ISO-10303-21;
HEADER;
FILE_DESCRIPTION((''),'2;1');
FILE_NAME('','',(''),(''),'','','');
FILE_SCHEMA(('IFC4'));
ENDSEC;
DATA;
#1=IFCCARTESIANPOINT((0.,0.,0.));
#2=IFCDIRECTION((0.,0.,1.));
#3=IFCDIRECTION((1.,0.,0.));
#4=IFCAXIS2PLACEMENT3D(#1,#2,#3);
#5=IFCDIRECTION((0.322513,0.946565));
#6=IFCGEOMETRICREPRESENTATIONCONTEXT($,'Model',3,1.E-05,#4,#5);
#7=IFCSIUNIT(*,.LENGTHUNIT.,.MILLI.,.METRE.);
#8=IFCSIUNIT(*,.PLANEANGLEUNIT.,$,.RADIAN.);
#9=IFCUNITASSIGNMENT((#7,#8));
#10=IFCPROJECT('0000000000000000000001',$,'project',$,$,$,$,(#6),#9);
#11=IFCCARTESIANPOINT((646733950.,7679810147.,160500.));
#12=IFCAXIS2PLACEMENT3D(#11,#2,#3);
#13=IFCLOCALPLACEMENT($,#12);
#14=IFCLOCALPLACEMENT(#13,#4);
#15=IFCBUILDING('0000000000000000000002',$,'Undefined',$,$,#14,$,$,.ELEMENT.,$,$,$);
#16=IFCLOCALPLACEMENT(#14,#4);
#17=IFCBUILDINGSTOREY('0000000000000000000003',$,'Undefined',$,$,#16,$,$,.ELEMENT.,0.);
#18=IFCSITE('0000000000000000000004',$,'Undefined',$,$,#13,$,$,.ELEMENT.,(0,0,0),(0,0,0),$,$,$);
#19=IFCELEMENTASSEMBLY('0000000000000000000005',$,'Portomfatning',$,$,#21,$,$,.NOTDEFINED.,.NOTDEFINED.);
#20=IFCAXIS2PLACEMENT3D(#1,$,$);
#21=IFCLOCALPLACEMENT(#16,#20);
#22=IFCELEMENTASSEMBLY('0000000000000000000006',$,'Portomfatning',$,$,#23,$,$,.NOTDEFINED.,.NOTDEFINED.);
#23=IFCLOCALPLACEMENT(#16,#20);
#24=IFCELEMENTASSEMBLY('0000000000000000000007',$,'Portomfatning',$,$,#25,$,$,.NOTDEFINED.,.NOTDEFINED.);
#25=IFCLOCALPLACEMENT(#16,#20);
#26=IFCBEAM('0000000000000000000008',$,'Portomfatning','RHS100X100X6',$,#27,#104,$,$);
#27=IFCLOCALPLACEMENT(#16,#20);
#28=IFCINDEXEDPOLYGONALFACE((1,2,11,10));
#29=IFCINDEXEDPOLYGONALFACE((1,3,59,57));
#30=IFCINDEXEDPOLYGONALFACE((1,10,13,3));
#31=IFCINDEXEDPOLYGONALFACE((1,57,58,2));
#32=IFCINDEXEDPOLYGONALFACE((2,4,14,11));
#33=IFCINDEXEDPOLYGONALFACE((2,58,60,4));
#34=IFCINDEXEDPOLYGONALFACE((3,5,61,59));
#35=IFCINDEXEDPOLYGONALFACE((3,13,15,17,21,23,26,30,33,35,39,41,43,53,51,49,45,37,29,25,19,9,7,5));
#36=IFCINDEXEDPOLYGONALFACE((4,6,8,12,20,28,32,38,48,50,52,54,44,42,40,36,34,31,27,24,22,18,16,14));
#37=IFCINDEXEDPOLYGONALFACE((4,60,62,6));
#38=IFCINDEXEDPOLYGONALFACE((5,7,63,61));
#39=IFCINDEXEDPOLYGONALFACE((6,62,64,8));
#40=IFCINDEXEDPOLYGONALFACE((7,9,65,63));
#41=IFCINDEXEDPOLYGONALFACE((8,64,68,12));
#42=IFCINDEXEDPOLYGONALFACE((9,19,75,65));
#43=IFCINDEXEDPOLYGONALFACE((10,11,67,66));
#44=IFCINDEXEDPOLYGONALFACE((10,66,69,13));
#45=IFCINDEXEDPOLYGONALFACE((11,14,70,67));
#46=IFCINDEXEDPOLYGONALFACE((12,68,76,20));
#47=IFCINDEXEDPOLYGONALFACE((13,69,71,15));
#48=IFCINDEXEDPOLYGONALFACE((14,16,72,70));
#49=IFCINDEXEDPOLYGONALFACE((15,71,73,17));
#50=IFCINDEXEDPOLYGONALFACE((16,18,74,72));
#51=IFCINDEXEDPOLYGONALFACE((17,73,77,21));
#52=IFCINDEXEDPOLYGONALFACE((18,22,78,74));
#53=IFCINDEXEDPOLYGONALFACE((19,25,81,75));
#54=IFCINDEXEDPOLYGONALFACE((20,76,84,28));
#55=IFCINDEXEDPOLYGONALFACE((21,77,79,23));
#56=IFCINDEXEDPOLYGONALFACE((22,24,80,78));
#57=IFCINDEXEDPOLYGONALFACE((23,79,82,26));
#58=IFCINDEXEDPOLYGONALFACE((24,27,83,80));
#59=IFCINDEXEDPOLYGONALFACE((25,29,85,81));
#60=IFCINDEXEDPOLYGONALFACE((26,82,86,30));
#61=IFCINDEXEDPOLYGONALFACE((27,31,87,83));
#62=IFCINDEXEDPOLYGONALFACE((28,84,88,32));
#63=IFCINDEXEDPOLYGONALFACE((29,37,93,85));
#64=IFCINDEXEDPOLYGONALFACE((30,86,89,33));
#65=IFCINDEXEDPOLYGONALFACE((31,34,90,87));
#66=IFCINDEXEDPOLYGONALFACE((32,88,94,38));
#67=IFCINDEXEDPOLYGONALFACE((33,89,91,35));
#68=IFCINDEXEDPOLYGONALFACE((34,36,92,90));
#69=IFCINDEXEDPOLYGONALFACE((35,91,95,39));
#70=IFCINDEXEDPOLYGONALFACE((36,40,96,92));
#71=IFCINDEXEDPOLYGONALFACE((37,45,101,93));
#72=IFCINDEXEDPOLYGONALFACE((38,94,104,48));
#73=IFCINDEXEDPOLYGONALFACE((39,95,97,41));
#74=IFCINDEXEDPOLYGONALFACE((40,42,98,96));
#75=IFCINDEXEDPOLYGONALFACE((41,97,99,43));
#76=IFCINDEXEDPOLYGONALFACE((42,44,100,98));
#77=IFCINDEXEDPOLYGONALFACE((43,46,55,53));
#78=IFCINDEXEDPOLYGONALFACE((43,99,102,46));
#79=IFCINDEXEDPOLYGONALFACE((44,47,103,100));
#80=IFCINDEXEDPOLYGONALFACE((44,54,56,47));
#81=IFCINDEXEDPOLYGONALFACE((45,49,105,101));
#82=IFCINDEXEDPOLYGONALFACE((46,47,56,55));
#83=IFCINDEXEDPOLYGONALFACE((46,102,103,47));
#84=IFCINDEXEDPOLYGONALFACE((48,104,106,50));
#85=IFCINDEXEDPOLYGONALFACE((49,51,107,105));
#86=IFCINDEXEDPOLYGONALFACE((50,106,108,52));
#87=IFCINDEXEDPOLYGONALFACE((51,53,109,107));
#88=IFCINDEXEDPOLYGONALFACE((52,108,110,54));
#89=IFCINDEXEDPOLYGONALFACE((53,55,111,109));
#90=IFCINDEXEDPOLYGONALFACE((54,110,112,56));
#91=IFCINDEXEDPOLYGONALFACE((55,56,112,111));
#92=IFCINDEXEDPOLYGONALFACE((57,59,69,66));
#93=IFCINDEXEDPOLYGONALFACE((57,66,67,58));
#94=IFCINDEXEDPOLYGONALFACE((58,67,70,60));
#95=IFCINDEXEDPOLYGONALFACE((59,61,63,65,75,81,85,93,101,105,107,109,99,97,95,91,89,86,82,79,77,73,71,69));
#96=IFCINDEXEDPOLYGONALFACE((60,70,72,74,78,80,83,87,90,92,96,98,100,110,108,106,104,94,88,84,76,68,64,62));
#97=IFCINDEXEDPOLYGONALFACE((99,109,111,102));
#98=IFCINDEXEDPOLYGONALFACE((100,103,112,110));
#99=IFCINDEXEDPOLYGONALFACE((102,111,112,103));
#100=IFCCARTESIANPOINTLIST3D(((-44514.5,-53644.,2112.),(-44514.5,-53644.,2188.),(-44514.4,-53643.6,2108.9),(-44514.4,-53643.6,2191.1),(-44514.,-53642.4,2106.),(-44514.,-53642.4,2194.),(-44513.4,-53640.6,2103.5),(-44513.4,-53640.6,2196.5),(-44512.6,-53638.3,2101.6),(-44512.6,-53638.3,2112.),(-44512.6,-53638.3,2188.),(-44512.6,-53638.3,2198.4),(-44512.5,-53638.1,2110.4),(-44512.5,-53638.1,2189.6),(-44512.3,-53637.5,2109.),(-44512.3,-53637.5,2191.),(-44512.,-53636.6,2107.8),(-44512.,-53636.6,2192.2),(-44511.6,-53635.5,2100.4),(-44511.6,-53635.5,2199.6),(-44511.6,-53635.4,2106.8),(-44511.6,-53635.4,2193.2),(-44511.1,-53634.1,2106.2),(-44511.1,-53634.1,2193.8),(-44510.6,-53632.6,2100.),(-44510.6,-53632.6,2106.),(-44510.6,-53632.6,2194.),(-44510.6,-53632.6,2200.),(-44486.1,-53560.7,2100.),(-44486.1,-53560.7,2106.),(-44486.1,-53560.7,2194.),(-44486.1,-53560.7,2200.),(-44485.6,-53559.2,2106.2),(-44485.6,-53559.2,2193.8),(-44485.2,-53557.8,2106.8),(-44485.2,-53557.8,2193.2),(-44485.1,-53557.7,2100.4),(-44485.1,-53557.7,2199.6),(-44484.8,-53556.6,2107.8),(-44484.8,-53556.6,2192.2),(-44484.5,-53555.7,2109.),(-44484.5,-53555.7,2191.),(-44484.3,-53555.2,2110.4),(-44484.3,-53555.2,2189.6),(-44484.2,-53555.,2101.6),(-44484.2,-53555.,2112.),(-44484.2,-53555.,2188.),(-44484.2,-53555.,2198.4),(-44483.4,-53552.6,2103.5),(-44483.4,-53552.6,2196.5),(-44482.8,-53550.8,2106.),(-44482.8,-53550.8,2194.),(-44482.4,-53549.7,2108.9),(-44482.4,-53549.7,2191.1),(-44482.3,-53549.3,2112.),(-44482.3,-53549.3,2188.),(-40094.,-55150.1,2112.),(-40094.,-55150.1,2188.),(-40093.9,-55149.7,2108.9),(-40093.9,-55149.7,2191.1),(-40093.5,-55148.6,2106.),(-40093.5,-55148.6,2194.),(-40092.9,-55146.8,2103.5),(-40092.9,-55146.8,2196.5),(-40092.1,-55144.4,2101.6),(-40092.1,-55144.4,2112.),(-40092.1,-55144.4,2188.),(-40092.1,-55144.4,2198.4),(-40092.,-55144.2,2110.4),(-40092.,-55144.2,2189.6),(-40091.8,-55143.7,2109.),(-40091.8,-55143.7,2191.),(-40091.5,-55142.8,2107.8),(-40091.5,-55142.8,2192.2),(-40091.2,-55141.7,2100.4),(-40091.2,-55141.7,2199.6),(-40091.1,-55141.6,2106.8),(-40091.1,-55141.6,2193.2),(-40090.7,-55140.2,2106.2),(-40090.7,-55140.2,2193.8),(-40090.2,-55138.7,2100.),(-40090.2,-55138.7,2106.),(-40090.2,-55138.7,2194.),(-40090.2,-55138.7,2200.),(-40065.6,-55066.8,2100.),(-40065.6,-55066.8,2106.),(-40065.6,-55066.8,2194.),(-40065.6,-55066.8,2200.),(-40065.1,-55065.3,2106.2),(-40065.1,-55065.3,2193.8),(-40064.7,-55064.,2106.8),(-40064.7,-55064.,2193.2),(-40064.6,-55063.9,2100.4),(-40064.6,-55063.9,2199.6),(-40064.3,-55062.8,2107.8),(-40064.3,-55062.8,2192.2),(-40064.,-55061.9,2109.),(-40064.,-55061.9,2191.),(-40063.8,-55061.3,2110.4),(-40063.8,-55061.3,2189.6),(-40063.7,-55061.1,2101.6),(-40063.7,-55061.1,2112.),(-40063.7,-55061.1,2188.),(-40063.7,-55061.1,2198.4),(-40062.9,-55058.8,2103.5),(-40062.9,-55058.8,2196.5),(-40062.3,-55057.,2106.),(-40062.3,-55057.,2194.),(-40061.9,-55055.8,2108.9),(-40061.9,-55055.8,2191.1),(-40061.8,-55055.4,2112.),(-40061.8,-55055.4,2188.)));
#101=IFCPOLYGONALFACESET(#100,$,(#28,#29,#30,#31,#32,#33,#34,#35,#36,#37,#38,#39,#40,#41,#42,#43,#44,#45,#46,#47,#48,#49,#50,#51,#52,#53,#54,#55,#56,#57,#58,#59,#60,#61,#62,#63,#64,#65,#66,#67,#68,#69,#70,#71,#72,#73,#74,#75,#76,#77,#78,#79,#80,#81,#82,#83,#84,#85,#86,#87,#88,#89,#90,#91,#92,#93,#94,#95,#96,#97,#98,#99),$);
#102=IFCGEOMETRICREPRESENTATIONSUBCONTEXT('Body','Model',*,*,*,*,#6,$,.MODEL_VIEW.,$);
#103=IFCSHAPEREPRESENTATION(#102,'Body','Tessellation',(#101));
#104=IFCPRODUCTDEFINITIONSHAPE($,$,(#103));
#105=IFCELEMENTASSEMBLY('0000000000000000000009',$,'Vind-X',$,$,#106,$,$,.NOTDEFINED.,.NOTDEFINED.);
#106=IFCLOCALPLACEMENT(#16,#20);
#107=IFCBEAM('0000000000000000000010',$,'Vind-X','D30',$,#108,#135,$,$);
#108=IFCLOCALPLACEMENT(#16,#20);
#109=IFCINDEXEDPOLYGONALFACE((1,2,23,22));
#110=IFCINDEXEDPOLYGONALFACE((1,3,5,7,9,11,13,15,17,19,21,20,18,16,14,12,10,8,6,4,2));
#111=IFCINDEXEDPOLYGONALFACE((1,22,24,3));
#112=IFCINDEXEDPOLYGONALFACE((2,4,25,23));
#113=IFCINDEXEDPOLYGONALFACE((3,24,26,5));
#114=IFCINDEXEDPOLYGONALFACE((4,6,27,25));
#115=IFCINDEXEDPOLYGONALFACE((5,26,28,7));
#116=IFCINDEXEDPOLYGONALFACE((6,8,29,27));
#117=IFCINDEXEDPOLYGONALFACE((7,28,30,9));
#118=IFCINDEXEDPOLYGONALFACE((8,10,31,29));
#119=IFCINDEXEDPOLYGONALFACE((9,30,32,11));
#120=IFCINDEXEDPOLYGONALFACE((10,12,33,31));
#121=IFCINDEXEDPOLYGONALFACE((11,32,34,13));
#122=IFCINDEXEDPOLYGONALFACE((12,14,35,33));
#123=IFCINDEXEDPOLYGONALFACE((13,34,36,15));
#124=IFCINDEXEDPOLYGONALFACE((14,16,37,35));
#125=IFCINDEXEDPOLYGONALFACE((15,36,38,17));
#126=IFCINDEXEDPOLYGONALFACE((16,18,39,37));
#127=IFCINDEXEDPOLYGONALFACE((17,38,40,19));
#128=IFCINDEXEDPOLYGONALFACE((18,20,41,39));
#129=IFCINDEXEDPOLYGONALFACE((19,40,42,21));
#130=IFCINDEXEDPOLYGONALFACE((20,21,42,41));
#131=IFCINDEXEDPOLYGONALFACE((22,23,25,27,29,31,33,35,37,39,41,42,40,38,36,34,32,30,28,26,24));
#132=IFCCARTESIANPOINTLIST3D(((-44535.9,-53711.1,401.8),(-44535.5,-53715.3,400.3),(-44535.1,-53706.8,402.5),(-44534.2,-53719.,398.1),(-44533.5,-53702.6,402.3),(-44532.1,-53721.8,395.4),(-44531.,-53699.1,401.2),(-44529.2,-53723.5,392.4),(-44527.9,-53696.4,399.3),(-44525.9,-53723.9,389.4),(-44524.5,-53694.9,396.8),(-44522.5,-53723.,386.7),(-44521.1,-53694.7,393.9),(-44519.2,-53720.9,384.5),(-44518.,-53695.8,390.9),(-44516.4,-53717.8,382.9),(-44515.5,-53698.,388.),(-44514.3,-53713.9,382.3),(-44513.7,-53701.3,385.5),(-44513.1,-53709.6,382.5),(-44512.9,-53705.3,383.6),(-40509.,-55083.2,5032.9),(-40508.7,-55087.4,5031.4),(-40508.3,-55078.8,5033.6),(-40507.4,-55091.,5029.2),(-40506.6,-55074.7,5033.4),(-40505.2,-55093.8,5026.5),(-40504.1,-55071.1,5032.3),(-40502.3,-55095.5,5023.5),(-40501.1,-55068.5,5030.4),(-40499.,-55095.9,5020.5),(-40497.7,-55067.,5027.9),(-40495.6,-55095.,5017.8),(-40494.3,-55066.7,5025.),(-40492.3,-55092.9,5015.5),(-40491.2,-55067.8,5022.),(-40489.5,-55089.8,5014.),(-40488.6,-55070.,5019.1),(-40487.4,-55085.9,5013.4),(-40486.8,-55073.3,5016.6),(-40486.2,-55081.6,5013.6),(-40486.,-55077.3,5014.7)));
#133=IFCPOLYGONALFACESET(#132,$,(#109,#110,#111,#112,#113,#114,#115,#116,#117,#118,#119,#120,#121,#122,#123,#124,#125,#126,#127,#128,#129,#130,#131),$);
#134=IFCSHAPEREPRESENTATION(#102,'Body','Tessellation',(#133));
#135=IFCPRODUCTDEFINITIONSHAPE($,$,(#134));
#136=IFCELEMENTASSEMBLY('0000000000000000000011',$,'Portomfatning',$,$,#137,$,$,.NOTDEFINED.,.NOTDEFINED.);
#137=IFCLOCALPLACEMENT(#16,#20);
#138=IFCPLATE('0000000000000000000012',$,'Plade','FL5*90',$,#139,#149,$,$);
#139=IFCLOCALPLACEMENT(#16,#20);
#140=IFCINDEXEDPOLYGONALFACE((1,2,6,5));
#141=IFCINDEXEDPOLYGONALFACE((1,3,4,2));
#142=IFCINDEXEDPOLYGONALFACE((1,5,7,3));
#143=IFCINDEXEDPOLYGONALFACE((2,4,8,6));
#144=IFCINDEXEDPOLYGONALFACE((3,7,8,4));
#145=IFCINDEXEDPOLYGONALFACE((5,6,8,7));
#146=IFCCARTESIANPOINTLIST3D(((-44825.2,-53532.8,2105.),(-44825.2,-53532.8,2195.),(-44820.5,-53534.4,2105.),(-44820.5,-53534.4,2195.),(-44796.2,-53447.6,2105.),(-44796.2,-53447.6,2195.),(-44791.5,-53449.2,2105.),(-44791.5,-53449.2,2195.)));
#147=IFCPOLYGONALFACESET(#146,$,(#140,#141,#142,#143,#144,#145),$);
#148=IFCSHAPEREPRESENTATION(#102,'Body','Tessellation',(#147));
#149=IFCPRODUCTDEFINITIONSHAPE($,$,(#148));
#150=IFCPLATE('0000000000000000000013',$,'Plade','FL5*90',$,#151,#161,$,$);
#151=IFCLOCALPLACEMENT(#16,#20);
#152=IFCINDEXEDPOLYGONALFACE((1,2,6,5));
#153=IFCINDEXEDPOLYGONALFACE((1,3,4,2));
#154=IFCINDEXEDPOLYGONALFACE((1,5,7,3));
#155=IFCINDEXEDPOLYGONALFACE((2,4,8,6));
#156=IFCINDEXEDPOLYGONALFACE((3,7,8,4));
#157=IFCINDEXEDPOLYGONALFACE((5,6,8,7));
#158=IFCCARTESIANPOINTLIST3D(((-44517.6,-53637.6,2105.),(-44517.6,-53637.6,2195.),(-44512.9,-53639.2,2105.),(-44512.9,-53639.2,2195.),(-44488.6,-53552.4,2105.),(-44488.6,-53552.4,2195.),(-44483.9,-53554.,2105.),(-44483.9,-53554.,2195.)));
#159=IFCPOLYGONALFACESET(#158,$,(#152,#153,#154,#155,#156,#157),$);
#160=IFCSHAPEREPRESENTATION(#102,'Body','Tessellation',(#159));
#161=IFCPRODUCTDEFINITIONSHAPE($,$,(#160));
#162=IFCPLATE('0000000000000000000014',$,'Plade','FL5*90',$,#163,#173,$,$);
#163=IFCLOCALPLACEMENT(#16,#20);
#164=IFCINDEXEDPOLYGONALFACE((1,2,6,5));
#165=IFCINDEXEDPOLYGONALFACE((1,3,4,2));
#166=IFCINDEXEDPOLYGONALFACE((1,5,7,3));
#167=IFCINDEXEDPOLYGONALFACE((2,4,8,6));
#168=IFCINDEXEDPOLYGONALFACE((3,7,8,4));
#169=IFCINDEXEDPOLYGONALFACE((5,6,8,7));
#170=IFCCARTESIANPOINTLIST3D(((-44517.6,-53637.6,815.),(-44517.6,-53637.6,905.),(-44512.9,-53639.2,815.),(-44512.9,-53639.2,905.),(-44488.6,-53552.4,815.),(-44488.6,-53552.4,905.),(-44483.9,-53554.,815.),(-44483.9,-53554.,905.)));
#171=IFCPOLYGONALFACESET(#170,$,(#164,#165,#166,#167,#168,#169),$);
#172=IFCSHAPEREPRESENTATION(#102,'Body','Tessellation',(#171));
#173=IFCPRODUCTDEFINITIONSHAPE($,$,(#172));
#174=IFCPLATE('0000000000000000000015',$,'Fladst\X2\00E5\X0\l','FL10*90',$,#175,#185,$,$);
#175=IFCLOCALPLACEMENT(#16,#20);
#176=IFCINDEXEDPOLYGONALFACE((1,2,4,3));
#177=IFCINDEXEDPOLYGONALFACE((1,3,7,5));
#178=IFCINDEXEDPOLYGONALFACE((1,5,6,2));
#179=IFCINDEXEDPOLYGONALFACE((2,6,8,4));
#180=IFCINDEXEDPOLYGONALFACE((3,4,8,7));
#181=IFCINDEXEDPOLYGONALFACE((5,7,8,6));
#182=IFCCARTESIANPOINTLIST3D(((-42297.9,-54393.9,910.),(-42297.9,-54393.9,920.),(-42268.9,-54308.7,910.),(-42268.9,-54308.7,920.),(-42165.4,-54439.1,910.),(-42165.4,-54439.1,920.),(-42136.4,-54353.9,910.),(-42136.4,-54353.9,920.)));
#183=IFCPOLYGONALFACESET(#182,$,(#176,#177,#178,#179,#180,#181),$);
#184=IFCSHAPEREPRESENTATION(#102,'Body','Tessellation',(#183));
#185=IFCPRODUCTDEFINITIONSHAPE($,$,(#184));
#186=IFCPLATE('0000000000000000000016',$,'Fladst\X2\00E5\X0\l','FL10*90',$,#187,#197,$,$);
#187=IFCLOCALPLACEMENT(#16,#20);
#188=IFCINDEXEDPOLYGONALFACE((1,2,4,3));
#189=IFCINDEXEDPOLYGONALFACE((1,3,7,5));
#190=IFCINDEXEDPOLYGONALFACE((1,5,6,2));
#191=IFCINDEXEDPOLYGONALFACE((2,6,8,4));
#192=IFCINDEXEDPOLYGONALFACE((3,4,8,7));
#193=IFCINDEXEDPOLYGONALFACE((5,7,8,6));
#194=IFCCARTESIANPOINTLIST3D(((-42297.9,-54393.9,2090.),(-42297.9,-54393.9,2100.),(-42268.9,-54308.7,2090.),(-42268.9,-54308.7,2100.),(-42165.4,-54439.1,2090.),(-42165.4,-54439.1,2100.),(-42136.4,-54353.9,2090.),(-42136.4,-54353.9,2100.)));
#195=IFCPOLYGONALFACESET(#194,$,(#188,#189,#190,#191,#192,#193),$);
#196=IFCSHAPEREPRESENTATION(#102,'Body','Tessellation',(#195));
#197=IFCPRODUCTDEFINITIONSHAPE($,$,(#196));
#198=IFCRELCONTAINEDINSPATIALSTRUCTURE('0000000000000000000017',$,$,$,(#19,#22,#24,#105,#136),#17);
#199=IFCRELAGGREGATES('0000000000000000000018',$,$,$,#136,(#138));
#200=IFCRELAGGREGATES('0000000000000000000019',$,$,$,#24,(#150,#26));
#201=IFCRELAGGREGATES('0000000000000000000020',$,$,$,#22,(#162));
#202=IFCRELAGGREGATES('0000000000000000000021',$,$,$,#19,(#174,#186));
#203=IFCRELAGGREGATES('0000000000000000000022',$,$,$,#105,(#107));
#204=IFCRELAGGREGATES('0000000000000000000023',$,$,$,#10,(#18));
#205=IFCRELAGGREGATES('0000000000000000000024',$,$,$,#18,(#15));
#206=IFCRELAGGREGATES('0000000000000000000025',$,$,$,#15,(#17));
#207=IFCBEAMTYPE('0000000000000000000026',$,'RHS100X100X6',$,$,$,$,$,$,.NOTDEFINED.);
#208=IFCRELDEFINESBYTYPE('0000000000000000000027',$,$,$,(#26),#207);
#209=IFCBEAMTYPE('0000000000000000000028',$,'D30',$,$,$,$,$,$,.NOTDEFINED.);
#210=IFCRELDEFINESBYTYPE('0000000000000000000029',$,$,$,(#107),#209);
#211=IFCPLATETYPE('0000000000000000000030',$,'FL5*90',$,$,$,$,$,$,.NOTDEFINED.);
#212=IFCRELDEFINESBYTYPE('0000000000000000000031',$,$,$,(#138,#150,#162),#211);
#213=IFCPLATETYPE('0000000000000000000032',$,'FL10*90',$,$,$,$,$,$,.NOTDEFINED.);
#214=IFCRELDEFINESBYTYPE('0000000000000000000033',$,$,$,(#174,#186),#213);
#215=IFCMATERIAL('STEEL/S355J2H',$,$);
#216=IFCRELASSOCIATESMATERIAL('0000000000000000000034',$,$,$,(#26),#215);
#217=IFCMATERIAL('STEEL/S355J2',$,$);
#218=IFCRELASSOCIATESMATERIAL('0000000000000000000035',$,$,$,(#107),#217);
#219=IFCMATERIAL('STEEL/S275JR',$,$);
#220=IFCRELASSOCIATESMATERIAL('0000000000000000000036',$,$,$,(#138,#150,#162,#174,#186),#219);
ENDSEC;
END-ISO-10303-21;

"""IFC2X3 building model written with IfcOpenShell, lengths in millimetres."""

from ifc_helpers import new_model, si_unit, direction, frame, origin_with_axes, origin_2d_with_axis, place, context, subcontext, project, spatial, polyline, hollow_rectangle, circle, outline, extrude, clip, halfspace, material, type_object, element, aggregate, save


model = new_model("IFC2X3")

# Units and contexts
model_context = context("Model", 3, precision=1e-05, world=origin_with_axes(), true_north=direction((0.322513, 0.946565)))
body_context = subcontext(model_context, "Body", "Model", "MODEL_VIEW")
ifc_project = project(units=[si_unit("LENGTHUNIT", "METRE", prefix="MILLI"), si_unit("PLANEANGLEUNIT", "RADIAN")], contexts=[model_context])

# Site, building, storey
site_placement = place(None, frame((646733950.0, 7679810147.0, 160500.0), z_axis=(0.0, 0.0, 1.0), x_axis=(1.0, 0.0, 0.0)))
site = spatial("IfcSite", under=ifc_project, at=site_placement, Name="Undefined", CompositionType="ELEMENT", RefLatitude=(0, 0, 0), RefLongitude=(0, 0, 0))
building_placement = place(site_placement, origin_with_axes())
building = spatial("IfcBuilding", under=site, at=building_placement, Name="Undefined", CompositionType="ELEMENT")
storey_placement = place(building_placement, origin_with_axes())
storey = spatial("IfcBuildingStorey", under=building, at=storey_placement, Name="Undefined", CompositionType="ELEMENT", Elevation=0.0)

# Element assembly
ifc_material_1 = material(Name="STEEL/S355J2H")
assembly_1_placement = place(storey_placement, origin_with_axes())
assembly_1 = element("IfcElementAssembly", 1, at=assembly_1_placement, inside=storey, Name="Portomfatning", AssemblyPlace="NOTDEFINED", PredefinedType="NOTDEFINED")

# Element assemblies, beams
beam_type_1 = type_object("IfcBeamType", Name="RHS100X100X6", PredefinedType="NOTDEFINED")
assembly_2_placement = place(storey_placement, origin_with_axes())
assembly_2 = element("IfcElementAssembly", 2, at=assembly_2_placement, inside=storey, Name="Portomfatning", AssemblyPlace="NOTDEFINED", PredefinedType="NOTDEFINED")
assembly_3_placement = place(storey_placement, origin_with_axes())
assembly_3 = element("IfcElementAssembly", 3, at=assembly_3_placement, inside=storey, Name="Portomfatning", AssemblyPlace="NOTDEFINED", PredefinedType="NOTDEFINED")
beam_1_placement = place(assembly_3_placement, frame((-44512.6, -53591.8, 2150.0), z_axis=(0.322513, 0.946565, 0.0), x_axis=(0.946565, -0.322513, 0.0)))
beam_1 = element("IfcBeam", 4, at=beam_1_placement, type_object=beam_type_1, material=ifc_material_1, Name="Portomfatning", Description="RHS100X100X6", context=body_context, shape_type="Clipping", body=[
    clip(clip(extrude(hollow_rectangle(XDim=100.0, YDim=100.0, WallThickness=6.0, InnerFilletRadius=6.0, OuterFilletRadius=12.0, at=origin_2d_with_axis()), frame((4746.7, 0.0, 0.0), z_axis=(-1.0, 0.0, 0.0), x_axis=(0.0, -1.0, 0.0)), (0.0, 0.0, 1.0), 4793.4), halfspace(frame((4685.0, -50.0, -50.0), z_axis=(-1.0, 0.0, 0.000185), x_axis=(0.0, 1.0, 0.0)), True)), halfspace(frame((15.0, 50.0, -50.0), z_axis=(1.0, 0.0, 0.000185), x_axis=(0.0, -1.0, 0.0)), True)),
])
assembly_4_placement = place(storey_placement, origin_with_axes())
assembly_4 = element("IfcElementAssembly", 5, at=assembly_4_placement, inside=storey, Name="Vind-X", AssemblyPlace="NOTDEFINED", PredefinedType="NOTDEFINED")
ifc_material_2 = material(Name="STEEL/S355J2")
beam_type_2 = type_object("IfcBeamType", Name="D30", PredefinedType="NOTDEFINED")
beam_2_placement = place(assembly_4_placement, frame((-44524.4, -53709.3, 392.4), z_axis=(-0.697089, 0.237512, 0.676502), x_axis=(0.640354, -0.218181, 0.73644)))
beam_2 = element("IfcBeam", 6, at=beam_2_placement, type_object=beam_type_2, material=ifc_material_2, Name="Vind-X", Description="D30", context=body_context, shape_type="SweptSolid", body=[
    extrude(circle(Radius=15.0, at=origin_2d_with_axis()), frame((6288.5, 0.0, 0.0), z_axis=(-1.0, 0.0, 0.0), x_axis=(0.0, -1.0, 0.0)), (0.0, 0.0, 1.0), 6288.5),
])

# Element assembly, plate
assembly_5_placement = place(storey_placement, origin_with_axes())
assembly_5 = element("IfcElementAssembly", 7, at=assembly_5_placement, inside=storey, Name="Portomfatning", AssemblyPlace="NOTDEFINED", PredefinedType="NOTDEFINED")
ifc_material_3 = material(Name="STEEL/S275JR")
plate_type_1 = type_object("IfcPlateType", Name="FL5*90", PredefinedType="NOTDEFINED")
plate_1_placement = place(assembly_5_placement, frame((-44793.8, -53448.4, 2105.0), z_axis=(0.946505, -0.322688, 0.0), x_axis=(0.0, 0.0, 1.0)))
plate_1 = element("IfcPlate", 8, at=plate_1_placement, type_object=plate_type_1, material=ifc_material_3, Name="Plade", Description="FL5*90", context=body_context, shape_type="SweptSolid", body=[
    extrude(outline(polyline([(0.0, 0.0), (90.0, 0.0), (90.0, 90.0), (0.0, 90.0), (0.0, 0.0)])), frame((0.0, 0.0, -2.5), z_axis=(0.0, 0.0, 1.0), x_axis=(1.0, 0.0, 0.0)), (0.0, 0.0, 1.0), 5.0),
])
aggregate(assembly_5, [plate_1])

# Plates
plate_2_placement = place(assembly_3_placement, frame((-44486.2, -53553.2, 2195.0), z_axis=(-0.946625, 0.322338, 0.0), x_axis=(0.0, 0.0, -1.0)))
plate_2 = element("IfcPlate", 9, at=plate_2_placement, type_object=plate_type_1, material=ifc_material_3, Name="Plade", Description="FL5*90", context=body_context, shape_type="SweptSolid", body=[
    extrude(outline(polyline([(0.0, 0.0), (90.0, 0.0), (90.0, 90.0), (0.0, 90.0), (0.0, 0.0)])), frame((0.0, 0.0, -2.5), z_axis=(0.0, 0.0, 1.0), x_axis=(1.0, 0.0, 0.0)), (0.0, 0.0, 1.0), 5.0),
])
aggregate(assembly_3, [plate_2, beam_1])
plate_3_placement = place(assembly_2_placement, frame((-44486.2, -53553.2, 905.0), z_axis=(-0.946625, 0.322338, 0.0), x_axis=(0.0, 0.0, -1.0)))
plate_3 = element("IfcPlate", 10, at=plate_3_placement, type_object=plate_type_1, material=ifc_material_3, Name="Plade", Description="FL5*90", context=body_context, shape_type="SweptSolid", body=[
    extrude(outline(polyline([(0.0, 0.0), (90.0, 0.0), (90.0, 90.0), (0.0, 90.0), (0.0, 0.0)])), frame((0.0, 0.0, -2.5), z_axis=(0.0, 0.0, 1.0), x_axis=(1.0, 0.0, 0.0)), (0.0, 0.0, 1.0), 5.0),
])
aggregate(assembly_2, [plate_3])
plate_type_2 = type_object("IfcPlateType", Name="FL10*90", PredefinedType="NOTDEFINED")
plate_4_placement = place(assembly_1_placement, frame((-42150.9, -54396.5, 915.0), z_axis=(0.0, 0.0, 1.0), x_axis=(-0.946565, 0.322513, 0.0)))
plate_4 = element("IfcPlate", 11, at=plate_4_placement, type_object=plate_type_2, material=ifc_material_3, Name="Fladstål", Description="FL10*90", context=body_context, shape_type="SweptSolid", body=[
    extrude(outline(polyline([(0.0, -45.0), (0.0, 45.0), (140.0, 45.0), (140.0, -45.0), (0.0, -45.0)])), frame((0.0, 0.0, -5.0), z_axis=(0.0, 0.0, 1.0), x_axis=(1.0, 0.0, 0.0)), (0.0, 0.0, 1.0), 10.0),
])
plate_5_placement = place(assembly_1_placement, frame((-42150.9, -54396.5, 2095.0), z_axis=(0.0, 0.0, -1.0), x_axis=(-0.946565, 0.322513, 0.0)))
plate_5 = element("IfcPlate", 12, at=plate_5_placement, type_object=plate_type_2, material=ifc_material_3, Name="Fladstål", Description="FL10*90", context=body_context, shape_type="SweptSolid", body=[
    extrude(outline(polyline([(0.0, -45.0), (0.0, 45.0), (140.0, 45.0), (140.0, -45.0), (0.0, -45.0)])), frame((0.0, 0.0, -5.0), z_axis=(0.0, 0.0, 1.0), x_axis=(1.0, 0.0, 0.0)), (0.0, 0.0, 1.0), 10.0),
])

aggregate(assembly_1, [plate_4, plate_5])
aggregate(assembly_4, [beam_2])

save(model, "model.ifc")
